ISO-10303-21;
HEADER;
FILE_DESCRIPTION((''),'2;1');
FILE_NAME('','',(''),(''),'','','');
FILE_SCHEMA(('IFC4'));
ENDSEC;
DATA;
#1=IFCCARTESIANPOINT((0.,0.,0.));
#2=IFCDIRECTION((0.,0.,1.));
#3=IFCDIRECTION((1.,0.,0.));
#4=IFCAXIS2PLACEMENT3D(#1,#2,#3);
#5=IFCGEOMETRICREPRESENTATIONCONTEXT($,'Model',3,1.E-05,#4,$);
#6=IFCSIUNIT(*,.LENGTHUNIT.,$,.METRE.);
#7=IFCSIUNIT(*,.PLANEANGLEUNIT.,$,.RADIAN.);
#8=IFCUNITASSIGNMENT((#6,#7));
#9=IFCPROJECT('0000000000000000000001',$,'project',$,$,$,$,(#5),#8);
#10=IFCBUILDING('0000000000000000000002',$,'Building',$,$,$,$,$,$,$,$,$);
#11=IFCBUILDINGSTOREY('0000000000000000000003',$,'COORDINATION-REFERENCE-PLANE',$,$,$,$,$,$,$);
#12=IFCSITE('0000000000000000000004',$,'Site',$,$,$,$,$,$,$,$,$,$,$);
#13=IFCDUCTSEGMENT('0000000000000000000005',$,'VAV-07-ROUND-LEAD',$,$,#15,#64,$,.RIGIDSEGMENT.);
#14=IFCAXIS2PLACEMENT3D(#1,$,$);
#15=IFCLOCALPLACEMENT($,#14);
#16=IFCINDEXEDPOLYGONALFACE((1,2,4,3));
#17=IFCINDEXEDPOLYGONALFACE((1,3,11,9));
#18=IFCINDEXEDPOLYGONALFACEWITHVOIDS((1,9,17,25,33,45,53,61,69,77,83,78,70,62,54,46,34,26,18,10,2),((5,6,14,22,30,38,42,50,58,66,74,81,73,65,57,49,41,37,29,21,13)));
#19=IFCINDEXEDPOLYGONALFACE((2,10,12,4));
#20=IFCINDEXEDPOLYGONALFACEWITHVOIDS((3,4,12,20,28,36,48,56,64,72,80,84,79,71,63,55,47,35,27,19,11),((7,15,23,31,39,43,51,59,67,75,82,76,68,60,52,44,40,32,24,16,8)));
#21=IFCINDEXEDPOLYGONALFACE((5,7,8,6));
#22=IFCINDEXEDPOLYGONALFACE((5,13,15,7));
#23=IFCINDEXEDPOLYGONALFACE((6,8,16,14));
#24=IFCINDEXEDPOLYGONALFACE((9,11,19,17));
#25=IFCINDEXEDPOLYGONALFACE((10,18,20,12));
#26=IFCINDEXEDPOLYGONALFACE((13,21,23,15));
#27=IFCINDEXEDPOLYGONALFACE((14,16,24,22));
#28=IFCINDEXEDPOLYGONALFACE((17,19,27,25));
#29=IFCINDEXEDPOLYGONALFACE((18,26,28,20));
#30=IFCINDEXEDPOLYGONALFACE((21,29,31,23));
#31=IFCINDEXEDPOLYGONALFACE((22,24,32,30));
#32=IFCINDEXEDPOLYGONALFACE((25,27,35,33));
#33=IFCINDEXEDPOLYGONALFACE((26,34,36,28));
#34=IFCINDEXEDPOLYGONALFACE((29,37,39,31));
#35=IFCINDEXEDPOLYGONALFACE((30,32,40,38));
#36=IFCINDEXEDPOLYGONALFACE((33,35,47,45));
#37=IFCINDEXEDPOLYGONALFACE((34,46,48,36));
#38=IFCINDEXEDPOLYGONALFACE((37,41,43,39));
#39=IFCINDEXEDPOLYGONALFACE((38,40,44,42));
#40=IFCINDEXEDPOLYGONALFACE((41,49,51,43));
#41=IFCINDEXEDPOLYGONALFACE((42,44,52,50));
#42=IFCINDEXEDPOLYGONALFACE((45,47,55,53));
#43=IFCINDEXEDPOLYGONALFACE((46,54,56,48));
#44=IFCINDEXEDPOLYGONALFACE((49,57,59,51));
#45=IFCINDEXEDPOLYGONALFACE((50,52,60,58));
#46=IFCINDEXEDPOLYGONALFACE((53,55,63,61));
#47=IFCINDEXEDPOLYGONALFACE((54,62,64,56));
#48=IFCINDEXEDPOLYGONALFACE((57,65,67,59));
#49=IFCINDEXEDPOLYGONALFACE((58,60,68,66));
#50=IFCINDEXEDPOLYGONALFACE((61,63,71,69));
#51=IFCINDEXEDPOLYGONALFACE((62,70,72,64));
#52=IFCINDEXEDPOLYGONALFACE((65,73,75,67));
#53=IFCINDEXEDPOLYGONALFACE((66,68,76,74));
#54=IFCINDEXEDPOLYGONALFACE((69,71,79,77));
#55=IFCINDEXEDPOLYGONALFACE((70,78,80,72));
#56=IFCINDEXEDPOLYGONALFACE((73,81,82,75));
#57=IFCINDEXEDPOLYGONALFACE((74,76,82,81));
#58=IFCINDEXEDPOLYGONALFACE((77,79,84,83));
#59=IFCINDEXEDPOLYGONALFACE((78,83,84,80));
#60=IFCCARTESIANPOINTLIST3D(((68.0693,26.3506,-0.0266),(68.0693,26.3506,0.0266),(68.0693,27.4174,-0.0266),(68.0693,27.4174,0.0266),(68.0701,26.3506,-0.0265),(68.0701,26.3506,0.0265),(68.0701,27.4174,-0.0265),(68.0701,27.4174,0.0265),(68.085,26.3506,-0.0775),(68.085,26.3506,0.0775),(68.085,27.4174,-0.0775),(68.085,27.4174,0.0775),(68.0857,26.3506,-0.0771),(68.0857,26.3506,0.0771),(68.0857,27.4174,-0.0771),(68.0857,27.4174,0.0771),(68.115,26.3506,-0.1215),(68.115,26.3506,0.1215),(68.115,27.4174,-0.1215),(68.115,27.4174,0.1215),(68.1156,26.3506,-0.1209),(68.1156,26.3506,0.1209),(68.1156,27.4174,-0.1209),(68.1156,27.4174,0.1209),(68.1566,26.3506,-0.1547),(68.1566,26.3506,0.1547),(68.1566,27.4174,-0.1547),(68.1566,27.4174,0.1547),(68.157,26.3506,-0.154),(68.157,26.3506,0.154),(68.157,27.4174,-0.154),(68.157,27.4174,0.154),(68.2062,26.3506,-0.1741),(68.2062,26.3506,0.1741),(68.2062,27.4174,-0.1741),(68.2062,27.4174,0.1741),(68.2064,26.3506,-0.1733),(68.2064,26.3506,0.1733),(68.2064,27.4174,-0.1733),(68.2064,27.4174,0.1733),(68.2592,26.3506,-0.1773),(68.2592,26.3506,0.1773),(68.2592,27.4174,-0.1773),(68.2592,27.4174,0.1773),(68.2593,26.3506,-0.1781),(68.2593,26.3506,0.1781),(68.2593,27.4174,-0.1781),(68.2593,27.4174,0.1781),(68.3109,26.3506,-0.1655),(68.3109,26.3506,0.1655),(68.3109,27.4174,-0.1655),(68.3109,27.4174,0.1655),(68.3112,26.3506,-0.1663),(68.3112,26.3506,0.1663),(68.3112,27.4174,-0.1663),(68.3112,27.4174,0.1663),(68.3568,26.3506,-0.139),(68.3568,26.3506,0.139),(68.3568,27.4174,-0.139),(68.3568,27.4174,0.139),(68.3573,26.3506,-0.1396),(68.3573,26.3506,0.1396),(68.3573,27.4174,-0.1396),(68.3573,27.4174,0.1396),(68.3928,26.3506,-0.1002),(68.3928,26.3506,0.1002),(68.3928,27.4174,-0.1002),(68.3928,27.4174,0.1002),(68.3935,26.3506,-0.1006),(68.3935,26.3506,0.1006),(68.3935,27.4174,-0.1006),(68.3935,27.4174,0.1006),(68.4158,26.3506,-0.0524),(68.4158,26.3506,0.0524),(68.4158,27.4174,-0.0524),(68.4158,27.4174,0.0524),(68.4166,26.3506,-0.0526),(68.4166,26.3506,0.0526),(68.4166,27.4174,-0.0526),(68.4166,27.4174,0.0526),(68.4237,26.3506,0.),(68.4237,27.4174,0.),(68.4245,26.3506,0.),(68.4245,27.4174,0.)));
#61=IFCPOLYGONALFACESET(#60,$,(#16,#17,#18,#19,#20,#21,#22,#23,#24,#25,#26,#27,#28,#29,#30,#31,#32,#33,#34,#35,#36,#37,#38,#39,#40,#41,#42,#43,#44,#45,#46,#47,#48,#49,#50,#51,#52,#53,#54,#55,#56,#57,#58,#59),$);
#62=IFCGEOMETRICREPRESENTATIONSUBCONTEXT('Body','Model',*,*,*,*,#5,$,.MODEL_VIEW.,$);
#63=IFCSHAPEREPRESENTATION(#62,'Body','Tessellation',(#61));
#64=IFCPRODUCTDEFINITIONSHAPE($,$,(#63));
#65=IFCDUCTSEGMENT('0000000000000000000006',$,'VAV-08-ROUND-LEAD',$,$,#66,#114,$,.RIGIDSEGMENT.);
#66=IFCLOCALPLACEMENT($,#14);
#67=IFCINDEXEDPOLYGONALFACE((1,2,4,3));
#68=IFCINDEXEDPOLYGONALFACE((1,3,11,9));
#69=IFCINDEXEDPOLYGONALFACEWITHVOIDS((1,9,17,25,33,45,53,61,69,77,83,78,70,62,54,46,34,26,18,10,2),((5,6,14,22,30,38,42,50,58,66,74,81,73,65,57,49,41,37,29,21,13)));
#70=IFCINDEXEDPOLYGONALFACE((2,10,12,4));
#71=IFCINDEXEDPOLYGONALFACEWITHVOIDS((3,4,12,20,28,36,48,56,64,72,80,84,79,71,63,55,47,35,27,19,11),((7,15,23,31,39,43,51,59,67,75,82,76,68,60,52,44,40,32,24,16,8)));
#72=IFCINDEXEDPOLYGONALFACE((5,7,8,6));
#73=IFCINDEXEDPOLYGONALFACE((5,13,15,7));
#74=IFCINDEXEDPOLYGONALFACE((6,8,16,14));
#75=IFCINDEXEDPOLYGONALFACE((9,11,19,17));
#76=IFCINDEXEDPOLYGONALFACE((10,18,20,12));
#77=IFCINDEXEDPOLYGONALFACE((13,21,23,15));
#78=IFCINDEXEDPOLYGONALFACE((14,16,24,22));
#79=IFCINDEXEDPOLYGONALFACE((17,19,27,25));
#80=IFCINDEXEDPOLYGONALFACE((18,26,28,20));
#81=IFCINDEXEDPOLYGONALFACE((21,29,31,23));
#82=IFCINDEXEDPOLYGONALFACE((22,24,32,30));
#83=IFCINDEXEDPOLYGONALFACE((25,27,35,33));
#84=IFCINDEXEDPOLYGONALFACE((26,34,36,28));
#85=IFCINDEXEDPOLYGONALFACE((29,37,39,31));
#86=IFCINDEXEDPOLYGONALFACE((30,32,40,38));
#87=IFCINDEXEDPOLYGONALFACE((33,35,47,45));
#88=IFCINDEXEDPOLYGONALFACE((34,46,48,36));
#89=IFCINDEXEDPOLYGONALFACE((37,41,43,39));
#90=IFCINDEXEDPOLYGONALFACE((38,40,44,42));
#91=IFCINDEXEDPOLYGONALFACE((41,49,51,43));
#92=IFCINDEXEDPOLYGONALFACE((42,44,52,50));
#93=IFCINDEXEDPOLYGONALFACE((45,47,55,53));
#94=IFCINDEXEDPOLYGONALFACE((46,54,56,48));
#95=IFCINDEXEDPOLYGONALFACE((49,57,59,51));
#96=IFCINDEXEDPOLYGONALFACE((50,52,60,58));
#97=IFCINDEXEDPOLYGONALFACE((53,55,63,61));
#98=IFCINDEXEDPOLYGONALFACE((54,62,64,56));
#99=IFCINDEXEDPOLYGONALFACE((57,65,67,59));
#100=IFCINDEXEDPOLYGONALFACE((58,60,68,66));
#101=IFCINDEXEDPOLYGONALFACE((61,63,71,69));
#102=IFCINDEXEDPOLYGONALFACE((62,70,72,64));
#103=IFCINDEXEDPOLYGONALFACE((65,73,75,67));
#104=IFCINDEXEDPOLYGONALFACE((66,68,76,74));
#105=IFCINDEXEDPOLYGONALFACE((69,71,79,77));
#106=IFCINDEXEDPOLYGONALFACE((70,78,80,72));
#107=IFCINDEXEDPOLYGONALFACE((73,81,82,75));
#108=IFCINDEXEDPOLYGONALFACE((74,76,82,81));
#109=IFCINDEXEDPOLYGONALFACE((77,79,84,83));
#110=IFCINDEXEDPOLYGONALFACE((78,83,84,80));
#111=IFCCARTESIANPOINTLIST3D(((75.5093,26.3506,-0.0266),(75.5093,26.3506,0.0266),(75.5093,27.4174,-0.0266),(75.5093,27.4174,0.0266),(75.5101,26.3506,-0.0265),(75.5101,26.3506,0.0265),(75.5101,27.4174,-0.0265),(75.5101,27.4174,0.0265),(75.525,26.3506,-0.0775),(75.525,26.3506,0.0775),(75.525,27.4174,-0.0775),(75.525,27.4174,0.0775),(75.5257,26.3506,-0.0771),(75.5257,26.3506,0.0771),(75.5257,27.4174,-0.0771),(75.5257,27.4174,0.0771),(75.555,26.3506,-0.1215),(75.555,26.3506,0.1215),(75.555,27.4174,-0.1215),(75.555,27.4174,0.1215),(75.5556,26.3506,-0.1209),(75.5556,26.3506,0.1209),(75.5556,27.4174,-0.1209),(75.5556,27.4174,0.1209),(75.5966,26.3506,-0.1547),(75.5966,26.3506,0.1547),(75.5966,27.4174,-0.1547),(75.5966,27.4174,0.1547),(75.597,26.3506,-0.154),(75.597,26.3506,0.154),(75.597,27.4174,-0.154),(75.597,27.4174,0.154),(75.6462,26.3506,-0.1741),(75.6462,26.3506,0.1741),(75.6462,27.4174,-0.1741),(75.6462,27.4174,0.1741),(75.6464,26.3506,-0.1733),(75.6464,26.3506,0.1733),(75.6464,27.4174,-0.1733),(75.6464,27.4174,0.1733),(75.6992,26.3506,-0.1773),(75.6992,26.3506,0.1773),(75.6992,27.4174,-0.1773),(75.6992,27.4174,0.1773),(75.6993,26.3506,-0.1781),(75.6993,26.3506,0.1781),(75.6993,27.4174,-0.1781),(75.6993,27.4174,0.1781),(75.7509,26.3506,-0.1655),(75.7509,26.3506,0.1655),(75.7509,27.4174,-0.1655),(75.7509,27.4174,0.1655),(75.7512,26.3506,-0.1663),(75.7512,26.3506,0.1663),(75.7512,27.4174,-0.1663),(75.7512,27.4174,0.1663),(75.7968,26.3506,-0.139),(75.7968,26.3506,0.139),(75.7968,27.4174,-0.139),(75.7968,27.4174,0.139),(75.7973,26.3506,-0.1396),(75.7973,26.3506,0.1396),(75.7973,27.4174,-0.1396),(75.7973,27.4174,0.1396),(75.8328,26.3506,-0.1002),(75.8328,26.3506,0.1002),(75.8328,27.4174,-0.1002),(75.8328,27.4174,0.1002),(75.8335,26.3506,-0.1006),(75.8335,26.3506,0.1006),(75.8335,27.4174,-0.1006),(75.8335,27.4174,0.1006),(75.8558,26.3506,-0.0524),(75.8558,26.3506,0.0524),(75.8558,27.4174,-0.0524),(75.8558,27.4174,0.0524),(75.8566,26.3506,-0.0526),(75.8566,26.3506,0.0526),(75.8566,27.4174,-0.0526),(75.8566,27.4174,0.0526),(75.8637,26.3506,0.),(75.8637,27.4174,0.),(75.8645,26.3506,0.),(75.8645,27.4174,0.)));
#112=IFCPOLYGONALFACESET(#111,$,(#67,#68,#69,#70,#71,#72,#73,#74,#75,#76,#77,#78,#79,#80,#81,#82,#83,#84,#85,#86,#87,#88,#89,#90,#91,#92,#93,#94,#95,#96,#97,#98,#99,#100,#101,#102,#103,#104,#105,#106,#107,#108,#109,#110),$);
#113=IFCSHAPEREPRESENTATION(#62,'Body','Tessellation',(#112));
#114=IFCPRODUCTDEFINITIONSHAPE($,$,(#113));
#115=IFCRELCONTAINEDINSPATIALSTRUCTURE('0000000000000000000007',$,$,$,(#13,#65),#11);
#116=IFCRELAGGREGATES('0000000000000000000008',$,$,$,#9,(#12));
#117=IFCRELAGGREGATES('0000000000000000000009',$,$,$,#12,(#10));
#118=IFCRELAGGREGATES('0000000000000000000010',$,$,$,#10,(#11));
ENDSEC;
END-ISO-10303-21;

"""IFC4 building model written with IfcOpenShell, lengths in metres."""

from ifc_helpers import new_model, si_unit, frame, origin, origin_with_axes, place, context, subcontext, project, spatial, hollow_circle, extrude, element, save


model = new_model("IFC4")

# Units and contexts
model_context = context("Model", 3, precision=1e-05, world=origin_with_axes())
body_context_1 = subcontext(model_context, "Body", "Model", "MODEL_VIEW")
ifc_project = project(units=[si_unit("LENGTHUNIT", "METRE"), si_unit("PLANEANGLEUNIT", "RADIAN")], contexts=[model_context])

# Site, building, storey
site = spatial("IfcSite", under=ifc_project, Name="Site")
building = spatial("IfcBuilding", under=site, Name="Building")
storey = spatial("IfcBuildingStorey", under=building, Name="COORDINATION-REFERENCE-PLANE")

# Duct segments
for number, where, z_axis, x_axis, name in (
    (1, (68.2459, 27.4174, 0.0), (0.0, -1.0, 0.0), (1.0, 0.0, 0.0), "VAV-07-ROUND-LEAD"),
    (2, (75.6859, 27.4174, 0.0), (0.0, -1.0, 0.0), (1.0, 0.0, 0.0), "VAV-08-ROUND-LEAD"),
):
    element("IfcDuctSegment", number, at=place(None, frame(where, z_axis=z_axis, x_axis=x_axis)), inside=storey, Name=name, PredefinedType="RIGIDSEGMENT", context=body_context_1, shape_type="SweptSolid", body=[
        extrude(hollow_circle(Radius=0.1786, WallThickness=0.0008), origin(), (0.0, 0.0, 1.0), 1.0668),
    ])

save(model, "model.ifc")
